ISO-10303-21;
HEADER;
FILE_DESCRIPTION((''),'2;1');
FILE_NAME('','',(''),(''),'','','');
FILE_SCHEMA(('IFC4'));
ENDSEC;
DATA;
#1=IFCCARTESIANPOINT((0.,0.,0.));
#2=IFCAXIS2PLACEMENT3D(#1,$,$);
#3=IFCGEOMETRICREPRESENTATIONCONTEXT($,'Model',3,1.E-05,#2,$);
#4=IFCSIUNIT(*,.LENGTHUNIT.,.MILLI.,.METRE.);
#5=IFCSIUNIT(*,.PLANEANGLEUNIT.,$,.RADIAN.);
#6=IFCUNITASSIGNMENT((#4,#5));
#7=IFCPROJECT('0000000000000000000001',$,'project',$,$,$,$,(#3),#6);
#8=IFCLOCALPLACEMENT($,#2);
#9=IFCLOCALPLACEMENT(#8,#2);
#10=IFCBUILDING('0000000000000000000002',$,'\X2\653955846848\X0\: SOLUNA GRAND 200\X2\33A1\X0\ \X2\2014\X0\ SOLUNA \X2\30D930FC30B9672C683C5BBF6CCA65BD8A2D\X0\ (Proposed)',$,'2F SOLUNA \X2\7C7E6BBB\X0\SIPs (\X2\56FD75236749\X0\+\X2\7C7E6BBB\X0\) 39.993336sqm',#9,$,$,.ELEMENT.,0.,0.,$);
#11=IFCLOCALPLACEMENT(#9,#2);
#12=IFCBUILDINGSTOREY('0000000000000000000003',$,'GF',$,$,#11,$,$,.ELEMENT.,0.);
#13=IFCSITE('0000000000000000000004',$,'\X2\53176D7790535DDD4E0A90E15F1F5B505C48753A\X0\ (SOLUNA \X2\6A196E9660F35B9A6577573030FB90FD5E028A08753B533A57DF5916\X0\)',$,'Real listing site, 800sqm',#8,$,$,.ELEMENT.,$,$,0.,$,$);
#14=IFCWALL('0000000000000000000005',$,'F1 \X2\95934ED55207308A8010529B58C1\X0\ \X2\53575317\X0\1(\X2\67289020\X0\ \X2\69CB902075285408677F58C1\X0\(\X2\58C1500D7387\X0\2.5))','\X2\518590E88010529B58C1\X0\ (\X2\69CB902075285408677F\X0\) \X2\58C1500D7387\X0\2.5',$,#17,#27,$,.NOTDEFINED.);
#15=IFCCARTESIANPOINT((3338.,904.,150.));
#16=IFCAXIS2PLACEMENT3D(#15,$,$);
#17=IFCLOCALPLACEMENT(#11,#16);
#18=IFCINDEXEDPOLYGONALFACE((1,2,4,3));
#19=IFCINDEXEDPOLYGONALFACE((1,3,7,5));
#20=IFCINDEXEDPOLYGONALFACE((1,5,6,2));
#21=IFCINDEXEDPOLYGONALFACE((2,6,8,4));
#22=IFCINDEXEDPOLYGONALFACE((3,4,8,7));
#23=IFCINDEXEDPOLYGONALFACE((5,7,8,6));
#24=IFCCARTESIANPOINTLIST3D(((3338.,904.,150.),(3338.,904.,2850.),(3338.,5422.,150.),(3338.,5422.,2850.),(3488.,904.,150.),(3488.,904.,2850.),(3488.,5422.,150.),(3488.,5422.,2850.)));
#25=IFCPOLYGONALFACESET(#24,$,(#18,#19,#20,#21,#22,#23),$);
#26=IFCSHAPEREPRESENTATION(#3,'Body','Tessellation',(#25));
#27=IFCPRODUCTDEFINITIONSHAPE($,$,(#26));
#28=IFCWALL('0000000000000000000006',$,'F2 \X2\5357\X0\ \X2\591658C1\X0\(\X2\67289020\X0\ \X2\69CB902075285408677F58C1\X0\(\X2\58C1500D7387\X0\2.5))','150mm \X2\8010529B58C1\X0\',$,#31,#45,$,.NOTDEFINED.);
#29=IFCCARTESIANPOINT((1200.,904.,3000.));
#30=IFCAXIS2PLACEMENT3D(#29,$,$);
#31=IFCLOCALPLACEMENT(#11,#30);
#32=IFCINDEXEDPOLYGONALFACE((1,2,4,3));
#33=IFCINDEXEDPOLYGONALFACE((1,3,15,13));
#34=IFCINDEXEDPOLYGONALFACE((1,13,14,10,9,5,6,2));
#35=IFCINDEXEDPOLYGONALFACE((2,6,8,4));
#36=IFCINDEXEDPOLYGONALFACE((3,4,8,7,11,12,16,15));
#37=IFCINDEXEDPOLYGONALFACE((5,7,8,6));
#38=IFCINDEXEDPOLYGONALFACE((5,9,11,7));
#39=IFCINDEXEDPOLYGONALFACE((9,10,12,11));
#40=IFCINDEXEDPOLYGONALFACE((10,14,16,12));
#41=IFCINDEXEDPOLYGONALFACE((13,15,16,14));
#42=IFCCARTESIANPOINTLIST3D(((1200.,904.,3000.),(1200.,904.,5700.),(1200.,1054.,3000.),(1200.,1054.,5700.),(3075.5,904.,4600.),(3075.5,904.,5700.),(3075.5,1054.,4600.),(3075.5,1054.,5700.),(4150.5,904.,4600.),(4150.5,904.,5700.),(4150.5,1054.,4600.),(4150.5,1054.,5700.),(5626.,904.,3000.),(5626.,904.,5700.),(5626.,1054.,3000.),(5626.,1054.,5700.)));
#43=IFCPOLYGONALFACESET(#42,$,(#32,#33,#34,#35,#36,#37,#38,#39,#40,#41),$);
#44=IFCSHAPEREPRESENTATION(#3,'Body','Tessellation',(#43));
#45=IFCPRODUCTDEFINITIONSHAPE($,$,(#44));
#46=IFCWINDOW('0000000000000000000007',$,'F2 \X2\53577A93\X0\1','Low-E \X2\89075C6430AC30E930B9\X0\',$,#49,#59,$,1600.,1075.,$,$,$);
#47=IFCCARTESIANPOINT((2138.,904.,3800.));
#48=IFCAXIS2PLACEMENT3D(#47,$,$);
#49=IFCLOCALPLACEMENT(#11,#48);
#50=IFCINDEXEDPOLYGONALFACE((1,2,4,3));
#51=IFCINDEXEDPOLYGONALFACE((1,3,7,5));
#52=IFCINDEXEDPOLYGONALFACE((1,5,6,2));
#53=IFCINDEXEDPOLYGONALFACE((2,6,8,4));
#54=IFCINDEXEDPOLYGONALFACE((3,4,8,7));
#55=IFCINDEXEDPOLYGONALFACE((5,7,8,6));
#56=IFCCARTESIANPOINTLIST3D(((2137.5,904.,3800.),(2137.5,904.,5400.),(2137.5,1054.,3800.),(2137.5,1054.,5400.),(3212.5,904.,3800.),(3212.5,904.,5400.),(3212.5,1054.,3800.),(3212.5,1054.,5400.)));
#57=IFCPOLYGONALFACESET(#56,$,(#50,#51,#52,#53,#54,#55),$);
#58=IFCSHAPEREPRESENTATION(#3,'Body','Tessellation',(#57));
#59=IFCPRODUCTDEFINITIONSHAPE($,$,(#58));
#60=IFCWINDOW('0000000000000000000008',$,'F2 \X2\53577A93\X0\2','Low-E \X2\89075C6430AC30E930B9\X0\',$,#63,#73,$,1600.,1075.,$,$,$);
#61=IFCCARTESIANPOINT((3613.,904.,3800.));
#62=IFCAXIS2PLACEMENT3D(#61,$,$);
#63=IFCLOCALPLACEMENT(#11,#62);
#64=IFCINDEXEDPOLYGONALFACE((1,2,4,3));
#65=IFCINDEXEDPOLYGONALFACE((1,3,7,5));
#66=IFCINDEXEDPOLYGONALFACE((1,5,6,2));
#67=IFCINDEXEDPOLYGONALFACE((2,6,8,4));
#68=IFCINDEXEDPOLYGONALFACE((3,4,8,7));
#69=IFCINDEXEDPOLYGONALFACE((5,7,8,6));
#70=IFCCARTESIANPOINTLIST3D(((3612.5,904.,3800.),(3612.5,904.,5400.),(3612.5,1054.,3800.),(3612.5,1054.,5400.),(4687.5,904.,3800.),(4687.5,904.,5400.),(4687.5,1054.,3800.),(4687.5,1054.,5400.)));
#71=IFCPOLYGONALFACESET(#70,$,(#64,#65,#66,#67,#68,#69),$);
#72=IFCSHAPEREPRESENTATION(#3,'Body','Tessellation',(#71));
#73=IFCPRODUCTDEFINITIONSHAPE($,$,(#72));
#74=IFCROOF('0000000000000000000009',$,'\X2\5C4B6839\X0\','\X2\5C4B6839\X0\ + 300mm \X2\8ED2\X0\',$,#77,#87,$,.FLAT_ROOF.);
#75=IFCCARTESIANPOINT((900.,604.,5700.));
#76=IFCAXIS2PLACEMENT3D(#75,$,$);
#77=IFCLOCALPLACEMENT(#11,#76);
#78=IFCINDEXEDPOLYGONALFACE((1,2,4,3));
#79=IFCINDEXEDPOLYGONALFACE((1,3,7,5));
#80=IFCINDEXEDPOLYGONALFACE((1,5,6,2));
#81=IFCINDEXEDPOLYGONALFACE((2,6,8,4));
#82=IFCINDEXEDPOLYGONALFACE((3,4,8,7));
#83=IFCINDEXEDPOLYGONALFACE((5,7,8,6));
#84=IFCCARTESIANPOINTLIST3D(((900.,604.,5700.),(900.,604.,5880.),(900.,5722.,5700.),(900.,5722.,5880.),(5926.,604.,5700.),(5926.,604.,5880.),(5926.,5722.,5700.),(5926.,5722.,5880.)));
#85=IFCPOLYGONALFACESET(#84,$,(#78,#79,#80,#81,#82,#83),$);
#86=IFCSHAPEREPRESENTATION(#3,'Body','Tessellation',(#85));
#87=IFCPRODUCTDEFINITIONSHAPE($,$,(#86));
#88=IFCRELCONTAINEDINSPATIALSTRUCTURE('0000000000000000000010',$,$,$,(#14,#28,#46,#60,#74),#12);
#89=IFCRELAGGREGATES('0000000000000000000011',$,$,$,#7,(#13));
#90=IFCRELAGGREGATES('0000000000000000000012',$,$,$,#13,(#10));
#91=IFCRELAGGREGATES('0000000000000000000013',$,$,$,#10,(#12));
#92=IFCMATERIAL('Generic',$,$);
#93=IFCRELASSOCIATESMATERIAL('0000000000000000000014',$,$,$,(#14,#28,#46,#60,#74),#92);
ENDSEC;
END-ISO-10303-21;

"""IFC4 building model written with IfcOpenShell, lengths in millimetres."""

from ifc_helpers import new_model, si_unit, frame, frame_2d, origin, place, context, project, spatial, rectangle, extrude, material, element, fill, save


model = new_model("IFC4")

# Units and contexts
model_context = context("Model", 3, precision=1e-05, world=origin())
ifc_project = project(units=[si_unit("LENGTHUNIT", "METRE", prefix="MILLI"), si_unit("PLANEANGLEUNIT", "RADIAN")], contexts=[model_context])

# Site, building, storey
site_placement = place(None, origin())
site = spatial("IfcSite", under=ifc_project, at=site_placement, Name="北海道川上郡弟子屈町 (SOLUNA 標準想定敷地・都市計画区域外)", ObjectType="Real listing site, 800sqm", CompositionType="ELEMENT", RefElevation=0.0)
building_placement = place(site_placement, origin())
building = spatial("IfcBuilding", under=site, at=building_placement, Name="改善案: SOLUNA GRAND 200㎡ — SOLUNA ベース本格宿泊施設 (Proposed)", ObjectType="2F SOLUNA 籾殻SIPs (国産杉+籾殻) 39.993336sqm", CompositionType="ELEMENT", ElevationOfRefHeight=0.0, ElevationOfTerrain=0.0)
storey_placement = place(building_placement, origin())
storey = spatial("IfcBuildingStorey", under=building, at=storey_placement, Name="GF", CompositionType="ELEMENT", Elevation=0.0)

# Shared definitions
ifc_material_1 = material(Name="Generic")

# Wall
wall_1_placement = place(storey_placement, frame((3338.0, 904.0, 150.0)))
element("IfcWall", 1, at=wall_1_placement, inside=storey, material=ifc_material_1, Name="F1 間仕切り耐力壁 南北1(木造 構造用合板壁(壁倍率2.5))", Description="内部耐力壁 (構造用合板) 壁倍率2.5", PredefinedType="NOTDEFINED", context=model_context, shape_type="SweptSolid", body=[
    extrude(rectangle(XDim=150.0, YDim=4518.0, at=frame_2d((75.0, 2259.0))), frame((3338.0, 904.0, 150.0)), (0.0, 0.0, 1.0), 2700.0),
])

# Wall, openings, windows
wall_2_placement = place(storey_placement, frame((1200.0, 904.0, 3000.0)))
wall_2 = element("IfcWall", 2, at=wall_2_placement, inside=storey, material=ifc_material_1, Name="F2 南 外壁(木造 構造用合板壁(壁倍率2.5))", Description="150mm 耐力壁", PredefinedType="NOTDEFINED", context=model_context, shape_type="SweptSolid", body=[
    extrude(rectangle(XDim=4426.0, YDim=150.0, at=frame_2d((2213.0, 75.0))), frame((1200.0, 904.0, 3000.0)), (0.0, 0.0, 1.0), 2700.0),
])
opening_1_placement = place(storey_placement, frame((2138.0, 904.0, 3800.0)))
opening_1 = element("IfcOpeningElement", 3, at=opening_1_placement, cuts=wall_2, PredefinedType="NOTDEFINED", context=model_context, shape_type="SweptSolid", body=[
    extrude(rectangle(XDim=1075.0, YDim=150.0, at=frame_2d((537.0, 75.0))), frame((2138.0, 904.0, 3800.0)), (0.0, 0.0, 1.0), 1600.0),
])
opening_2_placement = place(storey_placement, frame((3613.0, 904.0, 3800.0)))
opening_2 = element("IfcOpeningElement", 4, at=opening_2_placement, cuts=wall_2, PredefinedType="NOTDEFINED", context=model_context, shape_type="SweptSolid", body=[
    extrude(rectangle(XDim=1075.0, YDim=150.0, at=frame_2d((537.0, 75.0))), frame((3613.0, 904.0, 3800.0)), (0.0, 0.0, 1.0), 1600.0),
])
window_1_placement = place(storey_placement, frame((2138.0, 904.0, 3800.0)))
window_1 = element("IfcWindow", 5, at=window_1_placement, inside=storey, material=ifc_material_1, Name="F2 南窓1", Description="Low-E 複層ガラス", OverallHeight=1600.0, OverallWidth=1075.0, context=model_context, shape_type="SweptSolid", body=[
    extrude(rectangle(XDim=1075.0, YDim=150.0, at=frame_2d((537.0, 75.0))), frame((2138.0, 904.0, 3800.0)), (0.0, 0.0, 1.0), 1600.0),
])
fill(opening_1, window_1)
window_2_placement = place(storey_placement, frame((3613.0, 904.0, 3800.0)))
window_2 = element("IfcWindow", 6, at=window_2_placement, inside=storey, material=ifc_material_1, Name="F2 南窓2", Description="Low-E 複層ガラス", OverallHeight=1600.0, OverallWidth=1075.0, context=model_context, shape_type="SweptSolid", body=[
    extrude(rectangle(XDim=1075.0, YDim=150.0, at=frame_2d((537.0, 75.0))), frame((3613.0, 904.0, 3800.0)), (0.0, 0.0, 1.0), 1600.0),
])
fill(opening_2, window_2)

# Roof
roof_placement = place(storey_placement, frame((900.0, 604.0, 5700.0)))
element("IfcRoof", 7, at=roof_placement, inside=storey, material=ifc_material_1, Name="屋根", Description="屋根 + 300mm 軒", PredefinedType="FLAT_ROOF", context=model_context, shape_type="SweptSolid", body=[
    extrude(rectangle(XDim=5026.0, YDim=5118.0, at=frame_2d((2513.0, 2559.0))), frame((900.0, 604.0, 5700.0)), (0.0, 0.0, 1.0), 180.0),
])

save(model, "model.ifc")
